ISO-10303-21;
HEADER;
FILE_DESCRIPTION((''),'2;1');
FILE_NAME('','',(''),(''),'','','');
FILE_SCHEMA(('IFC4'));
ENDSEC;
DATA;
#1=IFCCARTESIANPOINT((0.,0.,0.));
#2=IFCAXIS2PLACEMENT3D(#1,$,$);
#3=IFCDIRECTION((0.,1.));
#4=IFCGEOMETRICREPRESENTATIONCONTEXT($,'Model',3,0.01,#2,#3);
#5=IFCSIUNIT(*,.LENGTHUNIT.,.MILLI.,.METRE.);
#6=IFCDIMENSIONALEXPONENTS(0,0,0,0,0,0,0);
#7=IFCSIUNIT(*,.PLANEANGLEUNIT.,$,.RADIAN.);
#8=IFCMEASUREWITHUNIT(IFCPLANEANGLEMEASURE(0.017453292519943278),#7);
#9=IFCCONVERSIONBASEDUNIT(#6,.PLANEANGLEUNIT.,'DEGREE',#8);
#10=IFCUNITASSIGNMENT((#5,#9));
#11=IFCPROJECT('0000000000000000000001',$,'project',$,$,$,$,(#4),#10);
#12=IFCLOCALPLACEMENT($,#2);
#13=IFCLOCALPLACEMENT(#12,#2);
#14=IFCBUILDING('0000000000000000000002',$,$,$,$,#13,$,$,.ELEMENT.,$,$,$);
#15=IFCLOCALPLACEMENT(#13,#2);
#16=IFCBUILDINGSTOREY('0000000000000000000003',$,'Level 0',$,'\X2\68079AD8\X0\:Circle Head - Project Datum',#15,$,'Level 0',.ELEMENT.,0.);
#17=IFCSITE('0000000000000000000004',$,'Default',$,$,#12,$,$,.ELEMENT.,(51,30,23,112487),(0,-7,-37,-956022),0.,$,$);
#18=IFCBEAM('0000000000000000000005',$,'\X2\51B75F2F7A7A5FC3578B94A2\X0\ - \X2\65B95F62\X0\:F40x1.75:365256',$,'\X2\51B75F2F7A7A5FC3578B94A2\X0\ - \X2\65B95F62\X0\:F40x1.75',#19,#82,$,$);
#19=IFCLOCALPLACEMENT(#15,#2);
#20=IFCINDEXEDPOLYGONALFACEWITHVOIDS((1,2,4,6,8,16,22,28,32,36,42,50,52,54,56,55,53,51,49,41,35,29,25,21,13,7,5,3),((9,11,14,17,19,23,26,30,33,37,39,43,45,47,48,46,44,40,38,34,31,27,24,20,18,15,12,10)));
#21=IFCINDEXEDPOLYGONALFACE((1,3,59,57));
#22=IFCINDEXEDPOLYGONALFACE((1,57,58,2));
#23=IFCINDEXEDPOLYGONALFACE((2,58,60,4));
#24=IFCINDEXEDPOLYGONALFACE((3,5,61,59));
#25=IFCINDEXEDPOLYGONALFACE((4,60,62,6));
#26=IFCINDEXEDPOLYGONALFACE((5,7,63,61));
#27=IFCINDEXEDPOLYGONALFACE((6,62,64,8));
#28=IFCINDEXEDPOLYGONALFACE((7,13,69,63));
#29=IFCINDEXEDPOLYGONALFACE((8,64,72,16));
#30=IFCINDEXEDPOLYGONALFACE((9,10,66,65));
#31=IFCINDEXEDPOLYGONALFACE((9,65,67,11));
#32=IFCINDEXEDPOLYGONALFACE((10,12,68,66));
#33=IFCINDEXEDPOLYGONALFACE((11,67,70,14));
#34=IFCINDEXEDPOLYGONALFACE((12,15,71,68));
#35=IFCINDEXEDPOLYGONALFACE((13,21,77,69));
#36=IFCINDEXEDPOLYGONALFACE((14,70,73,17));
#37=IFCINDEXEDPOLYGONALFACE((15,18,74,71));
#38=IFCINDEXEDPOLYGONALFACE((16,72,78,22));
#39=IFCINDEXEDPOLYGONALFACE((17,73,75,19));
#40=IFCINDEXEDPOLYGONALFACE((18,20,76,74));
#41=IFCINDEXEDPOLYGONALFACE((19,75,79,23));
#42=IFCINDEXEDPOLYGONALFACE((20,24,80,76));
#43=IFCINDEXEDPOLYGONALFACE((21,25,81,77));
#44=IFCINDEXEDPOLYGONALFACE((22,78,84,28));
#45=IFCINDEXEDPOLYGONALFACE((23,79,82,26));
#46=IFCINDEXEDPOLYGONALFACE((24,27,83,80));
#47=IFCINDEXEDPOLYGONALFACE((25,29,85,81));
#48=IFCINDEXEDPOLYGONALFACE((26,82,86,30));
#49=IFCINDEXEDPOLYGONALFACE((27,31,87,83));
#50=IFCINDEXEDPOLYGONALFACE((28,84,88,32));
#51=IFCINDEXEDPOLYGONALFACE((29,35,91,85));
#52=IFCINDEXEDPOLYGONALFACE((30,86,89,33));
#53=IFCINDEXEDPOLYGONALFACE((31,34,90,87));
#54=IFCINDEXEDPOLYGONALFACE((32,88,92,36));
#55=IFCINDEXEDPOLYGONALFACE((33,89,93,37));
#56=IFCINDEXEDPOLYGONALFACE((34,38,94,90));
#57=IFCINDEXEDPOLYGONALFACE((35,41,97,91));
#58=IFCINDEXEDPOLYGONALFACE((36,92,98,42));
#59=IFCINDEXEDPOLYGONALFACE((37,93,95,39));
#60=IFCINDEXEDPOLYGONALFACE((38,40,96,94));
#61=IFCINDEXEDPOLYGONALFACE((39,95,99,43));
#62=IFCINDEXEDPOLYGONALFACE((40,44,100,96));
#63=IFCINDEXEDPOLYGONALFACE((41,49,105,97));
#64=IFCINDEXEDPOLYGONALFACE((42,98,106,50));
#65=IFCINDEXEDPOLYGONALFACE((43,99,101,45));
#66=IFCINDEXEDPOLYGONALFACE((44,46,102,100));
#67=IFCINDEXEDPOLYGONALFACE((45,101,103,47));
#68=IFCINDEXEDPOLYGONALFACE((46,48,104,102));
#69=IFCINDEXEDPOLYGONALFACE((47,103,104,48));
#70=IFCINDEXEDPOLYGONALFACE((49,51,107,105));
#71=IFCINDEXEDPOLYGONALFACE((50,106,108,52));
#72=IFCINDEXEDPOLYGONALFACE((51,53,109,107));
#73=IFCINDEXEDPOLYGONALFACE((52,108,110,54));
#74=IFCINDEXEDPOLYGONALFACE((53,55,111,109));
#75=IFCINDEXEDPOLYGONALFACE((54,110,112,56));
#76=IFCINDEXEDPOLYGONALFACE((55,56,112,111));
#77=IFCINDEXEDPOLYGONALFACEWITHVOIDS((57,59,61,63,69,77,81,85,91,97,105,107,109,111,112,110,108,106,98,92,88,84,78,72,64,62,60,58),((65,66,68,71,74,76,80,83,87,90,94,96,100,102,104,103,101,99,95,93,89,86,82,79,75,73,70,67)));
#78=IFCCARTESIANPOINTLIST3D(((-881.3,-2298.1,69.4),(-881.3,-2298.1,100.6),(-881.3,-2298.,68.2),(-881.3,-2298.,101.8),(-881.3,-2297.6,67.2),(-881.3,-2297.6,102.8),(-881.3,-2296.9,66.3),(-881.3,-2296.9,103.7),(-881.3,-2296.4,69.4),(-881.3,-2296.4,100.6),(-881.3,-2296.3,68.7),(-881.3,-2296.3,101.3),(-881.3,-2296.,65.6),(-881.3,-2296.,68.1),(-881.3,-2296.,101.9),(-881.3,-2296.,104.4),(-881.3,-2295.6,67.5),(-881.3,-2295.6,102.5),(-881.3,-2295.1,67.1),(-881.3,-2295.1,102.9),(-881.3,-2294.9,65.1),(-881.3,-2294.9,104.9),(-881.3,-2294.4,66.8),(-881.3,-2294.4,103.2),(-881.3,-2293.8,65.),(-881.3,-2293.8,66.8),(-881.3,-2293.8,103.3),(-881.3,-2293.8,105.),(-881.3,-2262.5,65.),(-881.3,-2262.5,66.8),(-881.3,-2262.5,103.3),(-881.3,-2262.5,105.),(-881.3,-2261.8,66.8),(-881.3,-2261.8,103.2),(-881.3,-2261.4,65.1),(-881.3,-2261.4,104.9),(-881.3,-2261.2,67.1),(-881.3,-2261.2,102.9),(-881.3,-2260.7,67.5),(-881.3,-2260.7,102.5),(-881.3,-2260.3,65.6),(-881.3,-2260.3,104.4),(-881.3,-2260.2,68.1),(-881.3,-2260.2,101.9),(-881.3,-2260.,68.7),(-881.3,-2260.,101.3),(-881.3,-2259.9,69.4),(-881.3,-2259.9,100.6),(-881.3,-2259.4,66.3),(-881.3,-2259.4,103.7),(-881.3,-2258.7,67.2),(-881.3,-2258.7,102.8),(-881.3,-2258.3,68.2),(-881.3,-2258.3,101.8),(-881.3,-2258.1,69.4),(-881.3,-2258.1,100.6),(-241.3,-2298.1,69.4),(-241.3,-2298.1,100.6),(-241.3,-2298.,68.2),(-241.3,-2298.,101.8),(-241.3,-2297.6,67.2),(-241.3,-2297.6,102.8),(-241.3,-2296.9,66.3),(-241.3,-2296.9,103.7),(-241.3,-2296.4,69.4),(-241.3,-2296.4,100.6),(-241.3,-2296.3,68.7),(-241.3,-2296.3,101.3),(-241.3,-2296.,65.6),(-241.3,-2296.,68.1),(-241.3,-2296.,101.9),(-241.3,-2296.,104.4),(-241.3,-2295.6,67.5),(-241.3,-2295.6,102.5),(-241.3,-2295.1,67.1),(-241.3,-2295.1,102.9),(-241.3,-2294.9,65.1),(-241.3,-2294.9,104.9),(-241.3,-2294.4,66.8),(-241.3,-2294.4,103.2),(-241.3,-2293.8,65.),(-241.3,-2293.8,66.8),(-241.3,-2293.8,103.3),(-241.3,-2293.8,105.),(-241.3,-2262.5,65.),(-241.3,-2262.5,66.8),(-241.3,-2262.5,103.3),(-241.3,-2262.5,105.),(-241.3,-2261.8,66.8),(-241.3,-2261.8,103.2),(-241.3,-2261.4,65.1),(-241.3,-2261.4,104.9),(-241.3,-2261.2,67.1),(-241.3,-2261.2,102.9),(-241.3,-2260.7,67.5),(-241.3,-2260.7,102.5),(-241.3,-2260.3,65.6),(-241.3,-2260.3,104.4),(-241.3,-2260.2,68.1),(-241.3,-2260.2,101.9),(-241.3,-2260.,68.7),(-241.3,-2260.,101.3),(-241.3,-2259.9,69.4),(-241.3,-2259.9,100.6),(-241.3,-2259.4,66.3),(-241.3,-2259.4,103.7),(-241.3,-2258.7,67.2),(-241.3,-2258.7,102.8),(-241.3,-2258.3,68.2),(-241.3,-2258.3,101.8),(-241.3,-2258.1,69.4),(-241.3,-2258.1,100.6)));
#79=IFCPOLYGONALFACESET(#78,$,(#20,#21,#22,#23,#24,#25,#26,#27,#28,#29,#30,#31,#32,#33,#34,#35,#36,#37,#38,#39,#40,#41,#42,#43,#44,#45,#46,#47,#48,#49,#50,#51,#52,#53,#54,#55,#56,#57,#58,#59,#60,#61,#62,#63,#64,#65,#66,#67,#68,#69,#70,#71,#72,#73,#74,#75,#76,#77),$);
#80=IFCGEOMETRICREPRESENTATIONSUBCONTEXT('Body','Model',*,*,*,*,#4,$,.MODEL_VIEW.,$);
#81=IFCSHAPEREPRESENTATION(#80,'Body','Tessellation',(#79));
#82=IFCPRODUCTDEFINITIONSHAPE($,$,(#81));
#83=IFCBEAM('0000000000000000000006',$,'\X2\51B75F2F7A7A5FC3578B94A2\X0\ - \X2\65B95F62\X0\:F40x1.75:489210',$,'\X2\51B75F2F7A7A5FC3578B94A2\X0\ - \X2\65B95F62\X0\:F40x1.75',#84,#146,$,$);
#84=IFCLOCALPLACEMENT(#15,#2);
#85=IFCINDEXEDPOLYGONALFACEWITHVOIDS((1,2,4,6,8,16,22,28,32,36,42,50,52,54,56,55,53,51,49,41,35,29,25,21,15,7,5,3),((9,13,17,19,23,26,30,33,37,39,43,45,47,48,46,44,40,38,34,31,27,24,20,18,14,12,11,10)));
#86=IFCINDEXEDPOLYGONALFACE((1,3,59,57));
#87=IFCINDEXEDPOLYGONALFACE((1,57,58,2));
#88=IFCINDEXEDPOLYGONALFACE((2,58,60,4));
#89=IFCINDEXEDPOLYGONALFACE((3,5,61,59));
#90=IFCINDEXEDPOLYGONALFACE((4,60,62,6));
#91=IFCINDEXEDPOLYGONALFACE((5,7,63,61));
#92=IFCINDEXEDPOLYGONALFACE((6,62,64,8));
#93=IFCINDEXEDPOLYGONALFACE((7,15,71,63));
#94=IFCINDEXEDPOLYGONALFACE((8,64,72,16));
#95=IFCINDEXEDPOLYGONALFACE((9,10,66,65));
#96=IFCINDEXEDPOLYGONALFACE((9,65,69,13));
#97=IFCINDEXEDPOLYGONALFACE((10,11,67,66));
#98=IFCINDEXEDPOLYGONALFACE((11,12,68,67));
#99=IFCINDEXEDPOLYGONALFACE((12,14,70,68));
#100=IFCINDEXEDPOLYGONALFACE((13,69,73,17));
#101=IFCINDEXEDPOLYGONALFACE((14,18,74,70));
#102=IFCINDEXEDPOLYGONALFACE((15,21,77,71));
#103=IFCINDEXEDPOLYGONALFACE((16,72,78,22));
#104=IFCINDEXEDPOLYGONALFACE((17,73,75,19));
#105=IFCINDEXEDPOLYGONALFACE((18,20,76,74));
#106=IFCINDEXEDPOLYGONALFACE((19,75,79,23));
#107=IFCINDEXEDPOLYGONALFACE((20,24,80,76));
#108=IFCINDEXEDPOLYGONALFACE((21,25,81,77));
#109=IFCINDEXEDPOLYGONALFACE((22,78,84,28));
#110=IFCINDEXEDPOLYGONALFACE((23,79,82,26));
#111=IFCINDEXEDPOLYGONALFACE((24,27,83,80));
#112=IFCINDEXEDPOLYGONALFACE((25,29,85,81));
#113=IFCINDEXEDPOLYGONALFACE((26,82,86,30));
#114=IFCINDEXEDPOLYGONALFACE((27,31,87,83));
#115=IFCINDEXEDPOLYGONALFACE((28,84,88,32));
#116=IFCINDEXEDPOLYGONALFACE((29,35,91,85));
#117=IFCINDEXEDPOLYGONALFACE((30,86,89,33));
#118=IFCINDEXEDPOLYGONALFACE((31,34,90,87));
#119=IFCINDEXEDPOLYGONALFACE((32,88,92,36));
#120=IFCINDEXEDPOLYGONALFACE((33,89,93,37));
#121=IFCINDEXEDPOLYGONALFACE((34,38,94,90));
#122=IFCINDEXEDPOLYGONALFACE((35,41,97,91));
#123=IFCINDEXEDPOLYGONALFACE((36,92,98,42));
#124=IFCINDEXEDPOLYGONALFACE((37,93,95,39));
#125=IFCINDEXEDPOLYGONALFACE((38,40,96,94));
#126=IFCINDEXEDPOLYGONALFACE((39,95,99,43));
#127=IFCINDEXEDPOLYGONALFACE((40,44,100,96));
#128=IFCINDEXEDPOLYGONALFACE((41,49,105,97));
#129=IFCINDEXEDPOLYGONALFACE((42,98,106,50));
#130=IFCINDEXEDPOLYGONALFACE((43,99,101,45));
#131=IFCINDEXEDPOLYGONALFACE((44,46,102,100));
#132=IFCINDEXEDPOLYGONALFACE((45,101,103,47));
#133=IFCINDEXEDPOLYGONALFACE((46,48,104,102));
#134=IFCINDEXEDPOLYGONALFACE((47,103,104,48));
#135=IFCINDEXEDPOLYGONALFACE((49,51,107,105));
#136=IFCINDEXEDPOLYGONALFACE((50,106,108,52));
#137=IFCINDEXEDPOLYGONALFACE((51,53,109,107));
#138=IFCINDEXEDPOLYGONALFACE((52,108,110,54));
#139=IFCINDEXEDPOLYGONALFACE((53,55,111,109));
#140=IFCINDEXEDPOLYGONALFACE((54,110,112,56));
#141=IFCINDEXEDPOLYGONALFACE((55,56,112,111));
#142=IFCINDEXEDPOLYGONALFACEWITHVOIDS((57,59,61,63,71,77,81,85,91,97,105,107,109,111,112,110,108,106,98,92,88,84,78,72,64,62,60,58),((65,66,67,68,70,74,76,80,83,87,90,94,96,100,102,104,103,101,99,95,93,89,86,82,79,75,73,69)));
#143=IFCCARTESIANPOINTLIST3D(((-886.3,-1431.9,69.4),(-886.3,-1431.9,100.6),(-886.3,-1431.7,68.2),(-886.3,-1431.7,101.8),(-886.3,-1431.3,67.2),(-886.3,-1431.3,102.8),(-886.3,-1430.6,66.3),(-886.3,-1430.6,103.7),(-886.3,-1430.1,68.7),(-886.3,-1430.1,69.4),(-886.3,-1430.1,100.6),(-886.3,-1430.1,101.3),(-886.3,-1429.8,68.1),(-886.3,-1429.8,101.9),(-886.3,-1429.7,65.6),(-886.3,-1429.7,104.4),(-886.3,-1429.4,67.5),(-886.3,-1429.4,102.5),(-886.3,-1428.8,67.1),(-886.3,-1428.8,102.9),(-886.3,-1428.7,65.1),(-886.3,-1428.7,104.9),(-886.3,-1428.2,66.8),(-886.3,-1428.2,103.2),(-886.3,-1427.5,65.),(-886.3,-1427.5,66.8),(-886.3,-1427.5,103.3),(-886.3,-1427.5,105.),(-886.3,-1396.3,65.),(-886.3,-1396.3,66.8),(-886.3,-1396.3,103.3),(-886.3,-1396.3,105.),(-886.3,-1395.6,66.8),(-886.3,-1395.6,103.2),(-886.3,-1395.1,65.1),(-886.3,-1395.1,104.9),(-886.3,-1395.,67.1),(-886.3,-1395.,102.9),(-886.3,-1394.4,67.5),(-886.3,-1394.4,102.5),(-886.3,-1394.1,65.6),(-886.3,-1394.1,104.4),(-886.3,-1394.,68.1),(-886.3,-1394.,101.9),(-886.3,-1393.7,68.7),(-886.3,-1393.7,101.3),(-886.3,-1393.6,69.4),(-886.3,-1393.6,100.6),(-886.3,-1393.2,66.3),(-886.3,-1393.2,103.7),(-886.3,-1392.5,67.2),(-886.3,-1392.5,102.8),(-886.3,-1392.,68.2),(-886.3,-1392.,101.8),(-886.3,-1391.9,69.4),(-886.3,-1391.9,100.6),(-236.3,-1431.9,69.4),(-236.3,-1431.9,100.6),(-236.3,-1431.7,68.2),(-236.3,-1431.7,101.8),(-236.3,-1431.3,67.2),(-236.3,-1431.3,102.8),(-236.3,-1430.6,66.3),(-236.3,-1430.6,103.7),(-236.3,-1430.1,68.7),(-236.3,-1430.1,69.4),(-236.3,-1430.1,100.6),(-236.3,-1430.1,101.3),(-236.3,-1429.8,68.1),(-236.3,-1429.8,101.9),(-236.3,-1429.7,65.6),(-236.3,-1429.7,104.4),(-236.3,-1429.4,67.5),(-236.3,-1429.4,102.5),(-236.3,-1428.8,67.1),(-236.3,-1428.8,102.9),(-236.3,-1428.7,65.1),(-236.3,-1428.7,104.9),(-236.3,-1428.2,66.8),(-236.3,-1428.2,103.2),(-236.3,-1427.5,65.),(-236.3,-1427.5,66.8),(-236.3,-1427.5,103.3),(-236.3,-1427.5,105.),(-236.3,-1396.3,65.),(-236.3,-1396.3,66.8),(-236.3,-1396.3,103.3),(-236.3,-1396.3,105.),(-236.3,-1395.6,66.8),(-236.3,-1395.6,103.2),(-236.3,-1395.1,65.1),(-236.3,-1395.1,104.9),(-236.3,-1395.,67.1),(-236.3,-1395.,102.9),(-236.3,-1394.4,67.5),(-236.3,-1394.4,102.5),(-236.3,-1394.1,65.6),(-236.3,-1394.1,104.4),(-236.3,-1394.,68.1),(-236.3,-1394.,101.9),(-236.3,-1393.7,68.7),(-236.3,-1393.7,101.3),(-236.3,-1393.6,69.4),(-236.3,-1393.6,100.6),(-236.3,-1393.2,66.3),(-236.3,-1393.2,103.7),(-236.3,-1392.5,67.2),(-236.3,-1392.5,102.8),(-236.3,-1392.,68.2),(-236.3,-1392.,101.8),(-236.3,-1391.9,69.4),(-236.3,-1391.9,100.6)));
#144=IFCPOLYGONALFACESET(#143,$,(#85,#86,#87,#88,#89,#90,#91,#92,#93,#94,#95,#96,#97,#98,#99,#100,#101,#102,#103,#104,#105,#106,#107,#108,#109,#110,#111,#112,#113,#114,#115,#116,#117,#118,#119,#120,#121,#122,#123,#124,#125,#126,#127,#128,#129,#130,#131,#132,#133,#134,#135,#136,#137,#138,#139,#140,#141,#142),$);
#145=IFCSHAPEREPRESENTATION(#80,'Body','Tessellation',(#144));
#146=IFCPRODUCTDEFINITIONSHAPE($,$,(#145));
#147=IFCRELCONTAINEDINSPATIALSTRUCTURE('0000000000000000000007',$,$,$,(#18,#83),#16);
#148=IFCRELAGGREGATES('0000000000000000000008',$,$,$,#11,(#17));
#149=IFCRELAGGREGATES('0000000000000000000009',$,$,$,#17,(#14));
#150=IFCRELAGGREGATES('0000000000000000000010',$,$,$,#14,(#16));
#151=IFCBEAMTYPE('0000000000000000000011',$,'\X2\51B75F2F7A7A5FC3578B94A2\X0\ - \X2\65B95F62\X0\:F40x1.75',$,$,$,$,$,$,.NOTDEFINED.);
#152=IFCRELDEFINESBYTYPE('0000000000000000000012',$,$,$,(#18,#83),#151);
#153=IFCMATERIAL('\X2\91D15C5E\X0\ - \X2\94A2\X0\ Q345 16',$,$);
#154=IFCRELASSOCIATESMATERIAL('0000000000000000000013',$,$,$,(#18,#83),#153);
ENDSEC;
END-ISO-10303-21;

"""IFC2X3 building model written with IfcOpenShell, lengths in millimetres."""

from ifc_helpers import new_model, entity, si_unit, converted_unit, direction, frame, frame_2d, origin, place, context, subcontext, project, spatial, polyline, circle_curve, parameter, trimmed, segment, composite_curve, outline, extrude, material, type_object, element, save


model = new_model("IFC2X3")

# Units and contexts
model_context = context("Model", 3, precision=0.01, world=origin(), true_north=direction((0.0, 1.0)))
body_context = subcontext(model_context, "Body", "Model", "MODEL_VIEW")
ifc_project = project(units=[si_unit("LENGTHUNIT", "METRE", prefix="MILLI"), converted_unit("PLANEANGLEUNIT", "DEGREE", entity("IfcPlaneAngleMeasure", 0.017453292519943278), si_unit("PLANEANGLEUNIT", "RADIAN"), dimensions=[0, 0, 0, 0, 0, 0, 0])], contexts=[model_context])

# Site, building, storey
site_placement = place(None, origin())
site = spatial("IfcSite", under=ifc_project, at=site_placement, Name="Default", CompositionType="ELEMENT", RefLatitude=(51, 30, 23, 112487), RefLongitude=(0, -7, -37, -956022), RefElevation=0.0)
building_placement = place(site_placement, origin())
building = spatial("IfcBuilding", under=site, at=building_placement, CompositionType="ELEMENT")
storey_placement = place(building_placement, origin())
storey = spatial("IfcBuildingStorey", under=building, at=storey_placement, Name="Level 0", ObjectType="标高:Circle Head - Project Datum", LongName="Level 0", CompositionType="ELEMENT", Elevation=0.0)

# Beams
ifc_material_1 = material(Name="金属 - 钢 Q345 16")
beam_type_1 = type_object("IfcBeamType", Name="冷弯空心型钢 - 方形:F40x1.75", PredefinedType="NOTDEFINED")
beam_1_placement = place(storey_placement, frame((-376.3, -2278.1, 105.0), z_axis=(0.0, 0.0, 1.0), x_axis=(-1.0, 0.0, 0.0)))
element("IfcBeam", 1, at=beam_1_placement, inside=storey, type_object=beam_type_1, material=ifc_material_1, Name="冷弯空心型钢 - 方形:F40x1.75:365256", ObjectType="冷弯空心型钢 - 方形:F40x1.75", context=body_context, shape_type="SweptSolid", body=[
    extrude(outline(composite_curve([segment(trimmed(circle_curve(frame_2d((-15.6, 15.6), x_axis=(1.0, 0.0)), 4.4), [parameter(90.0)], [parameter(180.0)], True, "PARAMETER"), True, "CONTINUOUS"), segment(polyline([(-20.0, 15.6), (-20.0, -15.6)]), True, "CONTINUOUS"), segment(trimmed(circle_curve(frame_2d((-15.6, -15.6), x_axis=(1.0, 0.0)), 4.4), [parameter(180.0)], [parameter(270.0)], True, "PARAMETER"), True, "CONTINUOUS"), segment(polyline([(-15.6, -20.0), (15.6, -20.0)]), True, "CONTINUOUS"), segment(trimmed(circle_curve(frame_2d((15.6, -15.6), x_axis=(1.0, 0.0)), 4.4), [parameter(270.0)], [parameter(0.0)], True, "PARAMETER"), True, "CONTINUOUS"), segment(polyline([(20.0, -15.6), (20.0, 15.6)]), True, "CONTINUOUS"), segment(trimmed(circle_curve(frame_2d((15.6, 15.6), x_axis=(1.0, 0.0)), 4.4), [parameter(0.0)], [parameter(90.0)], True, "PARAMETER"), True, "CONTINUOUS"), segment(polyline([(15.6, 20.0), (-15.6, 20.0)]), True, "CONTINUOUS")], self_intersect=False), holes=[composite_curve([segment(polyline([(-15.6, 18.3), (15.6, 18.3)]), True, "CONTINUOUS"), segment(trimmed(circle_curve(frame_2d((15.6, 15.6), x_axis=(1.0, 0.0)), 2.6), [parameter(0.0)], [parameter(90.0)], True, "PARAMETER"), False, "CONTINUOUS"), segment(polyline([(18.2, 15.6), (18.2, -15.6)]), True, "CONTINUOUS"), segment(trimmed(circle_curve(frame_2d((15.6, -15.6), x_axis=(1.0, 0.0)), 2.6), [parameter(270.0)], [parameter(360.0)], True, "PARAMETER"), False, "CONTINUOUS"), segment(polyline([(15.6, -18.2), (-15.6, -18.2)]), True, "CONTINUOUS"), segment(trimmed(circle_curve(frame_2d((-15.6, -15.6), x_axis=(1.0, 0.0)), 2.6), [parameter(180.0)], [parameter(270.0)], True, "PARAMETER"), False, "CONTINUOUS"), segment(polyline([(-18.3, -15.6), (-18.3, 15.6)]), True, "CONTINUOUS"), segment(trimmed(circle_curve(frame_2d((-15.6, 15.6), x_axis=(1.0, 0.0)), 2.6), [parameter(90.0)], [parameter(180.0)], True, "PARAMETER"), False, "CONTINUOUS")], self_intersect=False)]), frame((-135.0, 0.0, -20.0), z_axis=(1.0, 0.0, 0.0), x_axis=(0.0, 1.0, 0.0)), (0.0, 0.0, 1.0), 640.0),
])
beam_2_placement = place(storey_placement, frame((-821.3, -1411.9, 105.0)))
element("IfcBeam", 2, at=beam_2_placement, inside=storey, type_object=beam_type_1, material=ifc_material_1, Name="冷弯空心型钢 - 方形:F40x1.75:489210", ObjectType="冷弯空心型钢 - 方形:F40x1.75", context=body_context, shape_type="SweptSolid", body=[
    extrude(outline(composite_curve([segment(trimmed(circle_curve(frame_2d((-15.6, 15.6), x_axis=(1.0, 0.0)), 4.4), [parameter(90.0)], [parameter(180.0)], True, "PARAMETER"), True, "CONTINUOUS"), segment(polyline([(-20.0, 15.6), (-20.0, -15.6)]), True, "CONTINUOUS"), segment(trimmed(circle_curve(frame_2d((-15.6, -15.6), x_axis=(1.0, 0.0)), 4.4), [parameter(180.0)], [parameter(270.0)], True, "PARAMETER"), True, "CONTINUOUS"), segment(polyline([(-15.6, -20.0), (15.6, -20.0)]), True, "CONTINUOUS"), segment(trimmed(circle_curve(frame_2d((15.6, -15.6), x_axis=(1.0, 0.0)), 4.4), [parameter(270.0)], [parameter(0.0)], True, "PARAMETER"), True, "CONTINUOUS"), segment(polyline([(20.0, -15.6), (20.0, 15.6)]), True, "CONTINUOUS"), segment(trimmed(circle_curve(frame_2d((15.6, 15.6), x_axis=(1.0, 0.0)), 4.4), [parameter(0.0)], [parameter(90.0)], True, "PARAMETER"), True, "CONTINUOUS"), segment(polyline([(15.6, 20.0), (-15.6, 20.0)]), True, "CONTINUOUS")], self_intersect=False), holes=[composite_curve([segment(polyline([(-15.6, 18.3), (15.6, 18.3)]), True, "CONTINUOUS"), segment(trimmed(circle_curve(frame_2d((15.6, 15.6), x_axis=(1.0, 0.0)), 2.6), [parameter(0.0)], [parameter(90.0)], True, "PARAMETER"), False, "CONTINUOUS"), segment(polyline([(18.2, 15.6), (18.2, -15.6)]), True, "CONTINUOUS"), segment(trimmed(circle_curve(frame_2d((15.6, -15.6), x_axis=(1.0, 0.0)), 2.6), [parameter(270.0)], [parameter(360.0)], True, "PARAMETER"), False, "CONTINUOUS"), segment(polyline([(15.6, -18.2), (-15.6, -18.2)]), True, "CONTINUOUS"), segment(trimmed(circle_curve(frame_2d((-15.6, -15.6), x_axis=(1.0, 0.0)), 2.6), [parameter(180.0)], [parameter(270.0)], True, "PARAMETER"), False, "CONTINUOUS"), segment(polyline([(-18.3, -15.6), (-18.3, 15.6)]), True, "CONTINUOUS"), segment(trimmed(circle_curve(frame_2d((-15.6, 15.6), x_axis=(1.0, 0.0)), 2.6), [parameter(90.0)], [parameter(180.0)], True, "PARAMETER"), False, "CONTINUOUS")], self_intersect=False)]), frame((-65.0, 0.0, -20.0), z_axis=(1.0, 0.0, 0.0), x_axis=(0.0, 1.0, 0.0)), (0.0, 0.0, 1.0), 650.0),
])

save(model, "model.ifc")
